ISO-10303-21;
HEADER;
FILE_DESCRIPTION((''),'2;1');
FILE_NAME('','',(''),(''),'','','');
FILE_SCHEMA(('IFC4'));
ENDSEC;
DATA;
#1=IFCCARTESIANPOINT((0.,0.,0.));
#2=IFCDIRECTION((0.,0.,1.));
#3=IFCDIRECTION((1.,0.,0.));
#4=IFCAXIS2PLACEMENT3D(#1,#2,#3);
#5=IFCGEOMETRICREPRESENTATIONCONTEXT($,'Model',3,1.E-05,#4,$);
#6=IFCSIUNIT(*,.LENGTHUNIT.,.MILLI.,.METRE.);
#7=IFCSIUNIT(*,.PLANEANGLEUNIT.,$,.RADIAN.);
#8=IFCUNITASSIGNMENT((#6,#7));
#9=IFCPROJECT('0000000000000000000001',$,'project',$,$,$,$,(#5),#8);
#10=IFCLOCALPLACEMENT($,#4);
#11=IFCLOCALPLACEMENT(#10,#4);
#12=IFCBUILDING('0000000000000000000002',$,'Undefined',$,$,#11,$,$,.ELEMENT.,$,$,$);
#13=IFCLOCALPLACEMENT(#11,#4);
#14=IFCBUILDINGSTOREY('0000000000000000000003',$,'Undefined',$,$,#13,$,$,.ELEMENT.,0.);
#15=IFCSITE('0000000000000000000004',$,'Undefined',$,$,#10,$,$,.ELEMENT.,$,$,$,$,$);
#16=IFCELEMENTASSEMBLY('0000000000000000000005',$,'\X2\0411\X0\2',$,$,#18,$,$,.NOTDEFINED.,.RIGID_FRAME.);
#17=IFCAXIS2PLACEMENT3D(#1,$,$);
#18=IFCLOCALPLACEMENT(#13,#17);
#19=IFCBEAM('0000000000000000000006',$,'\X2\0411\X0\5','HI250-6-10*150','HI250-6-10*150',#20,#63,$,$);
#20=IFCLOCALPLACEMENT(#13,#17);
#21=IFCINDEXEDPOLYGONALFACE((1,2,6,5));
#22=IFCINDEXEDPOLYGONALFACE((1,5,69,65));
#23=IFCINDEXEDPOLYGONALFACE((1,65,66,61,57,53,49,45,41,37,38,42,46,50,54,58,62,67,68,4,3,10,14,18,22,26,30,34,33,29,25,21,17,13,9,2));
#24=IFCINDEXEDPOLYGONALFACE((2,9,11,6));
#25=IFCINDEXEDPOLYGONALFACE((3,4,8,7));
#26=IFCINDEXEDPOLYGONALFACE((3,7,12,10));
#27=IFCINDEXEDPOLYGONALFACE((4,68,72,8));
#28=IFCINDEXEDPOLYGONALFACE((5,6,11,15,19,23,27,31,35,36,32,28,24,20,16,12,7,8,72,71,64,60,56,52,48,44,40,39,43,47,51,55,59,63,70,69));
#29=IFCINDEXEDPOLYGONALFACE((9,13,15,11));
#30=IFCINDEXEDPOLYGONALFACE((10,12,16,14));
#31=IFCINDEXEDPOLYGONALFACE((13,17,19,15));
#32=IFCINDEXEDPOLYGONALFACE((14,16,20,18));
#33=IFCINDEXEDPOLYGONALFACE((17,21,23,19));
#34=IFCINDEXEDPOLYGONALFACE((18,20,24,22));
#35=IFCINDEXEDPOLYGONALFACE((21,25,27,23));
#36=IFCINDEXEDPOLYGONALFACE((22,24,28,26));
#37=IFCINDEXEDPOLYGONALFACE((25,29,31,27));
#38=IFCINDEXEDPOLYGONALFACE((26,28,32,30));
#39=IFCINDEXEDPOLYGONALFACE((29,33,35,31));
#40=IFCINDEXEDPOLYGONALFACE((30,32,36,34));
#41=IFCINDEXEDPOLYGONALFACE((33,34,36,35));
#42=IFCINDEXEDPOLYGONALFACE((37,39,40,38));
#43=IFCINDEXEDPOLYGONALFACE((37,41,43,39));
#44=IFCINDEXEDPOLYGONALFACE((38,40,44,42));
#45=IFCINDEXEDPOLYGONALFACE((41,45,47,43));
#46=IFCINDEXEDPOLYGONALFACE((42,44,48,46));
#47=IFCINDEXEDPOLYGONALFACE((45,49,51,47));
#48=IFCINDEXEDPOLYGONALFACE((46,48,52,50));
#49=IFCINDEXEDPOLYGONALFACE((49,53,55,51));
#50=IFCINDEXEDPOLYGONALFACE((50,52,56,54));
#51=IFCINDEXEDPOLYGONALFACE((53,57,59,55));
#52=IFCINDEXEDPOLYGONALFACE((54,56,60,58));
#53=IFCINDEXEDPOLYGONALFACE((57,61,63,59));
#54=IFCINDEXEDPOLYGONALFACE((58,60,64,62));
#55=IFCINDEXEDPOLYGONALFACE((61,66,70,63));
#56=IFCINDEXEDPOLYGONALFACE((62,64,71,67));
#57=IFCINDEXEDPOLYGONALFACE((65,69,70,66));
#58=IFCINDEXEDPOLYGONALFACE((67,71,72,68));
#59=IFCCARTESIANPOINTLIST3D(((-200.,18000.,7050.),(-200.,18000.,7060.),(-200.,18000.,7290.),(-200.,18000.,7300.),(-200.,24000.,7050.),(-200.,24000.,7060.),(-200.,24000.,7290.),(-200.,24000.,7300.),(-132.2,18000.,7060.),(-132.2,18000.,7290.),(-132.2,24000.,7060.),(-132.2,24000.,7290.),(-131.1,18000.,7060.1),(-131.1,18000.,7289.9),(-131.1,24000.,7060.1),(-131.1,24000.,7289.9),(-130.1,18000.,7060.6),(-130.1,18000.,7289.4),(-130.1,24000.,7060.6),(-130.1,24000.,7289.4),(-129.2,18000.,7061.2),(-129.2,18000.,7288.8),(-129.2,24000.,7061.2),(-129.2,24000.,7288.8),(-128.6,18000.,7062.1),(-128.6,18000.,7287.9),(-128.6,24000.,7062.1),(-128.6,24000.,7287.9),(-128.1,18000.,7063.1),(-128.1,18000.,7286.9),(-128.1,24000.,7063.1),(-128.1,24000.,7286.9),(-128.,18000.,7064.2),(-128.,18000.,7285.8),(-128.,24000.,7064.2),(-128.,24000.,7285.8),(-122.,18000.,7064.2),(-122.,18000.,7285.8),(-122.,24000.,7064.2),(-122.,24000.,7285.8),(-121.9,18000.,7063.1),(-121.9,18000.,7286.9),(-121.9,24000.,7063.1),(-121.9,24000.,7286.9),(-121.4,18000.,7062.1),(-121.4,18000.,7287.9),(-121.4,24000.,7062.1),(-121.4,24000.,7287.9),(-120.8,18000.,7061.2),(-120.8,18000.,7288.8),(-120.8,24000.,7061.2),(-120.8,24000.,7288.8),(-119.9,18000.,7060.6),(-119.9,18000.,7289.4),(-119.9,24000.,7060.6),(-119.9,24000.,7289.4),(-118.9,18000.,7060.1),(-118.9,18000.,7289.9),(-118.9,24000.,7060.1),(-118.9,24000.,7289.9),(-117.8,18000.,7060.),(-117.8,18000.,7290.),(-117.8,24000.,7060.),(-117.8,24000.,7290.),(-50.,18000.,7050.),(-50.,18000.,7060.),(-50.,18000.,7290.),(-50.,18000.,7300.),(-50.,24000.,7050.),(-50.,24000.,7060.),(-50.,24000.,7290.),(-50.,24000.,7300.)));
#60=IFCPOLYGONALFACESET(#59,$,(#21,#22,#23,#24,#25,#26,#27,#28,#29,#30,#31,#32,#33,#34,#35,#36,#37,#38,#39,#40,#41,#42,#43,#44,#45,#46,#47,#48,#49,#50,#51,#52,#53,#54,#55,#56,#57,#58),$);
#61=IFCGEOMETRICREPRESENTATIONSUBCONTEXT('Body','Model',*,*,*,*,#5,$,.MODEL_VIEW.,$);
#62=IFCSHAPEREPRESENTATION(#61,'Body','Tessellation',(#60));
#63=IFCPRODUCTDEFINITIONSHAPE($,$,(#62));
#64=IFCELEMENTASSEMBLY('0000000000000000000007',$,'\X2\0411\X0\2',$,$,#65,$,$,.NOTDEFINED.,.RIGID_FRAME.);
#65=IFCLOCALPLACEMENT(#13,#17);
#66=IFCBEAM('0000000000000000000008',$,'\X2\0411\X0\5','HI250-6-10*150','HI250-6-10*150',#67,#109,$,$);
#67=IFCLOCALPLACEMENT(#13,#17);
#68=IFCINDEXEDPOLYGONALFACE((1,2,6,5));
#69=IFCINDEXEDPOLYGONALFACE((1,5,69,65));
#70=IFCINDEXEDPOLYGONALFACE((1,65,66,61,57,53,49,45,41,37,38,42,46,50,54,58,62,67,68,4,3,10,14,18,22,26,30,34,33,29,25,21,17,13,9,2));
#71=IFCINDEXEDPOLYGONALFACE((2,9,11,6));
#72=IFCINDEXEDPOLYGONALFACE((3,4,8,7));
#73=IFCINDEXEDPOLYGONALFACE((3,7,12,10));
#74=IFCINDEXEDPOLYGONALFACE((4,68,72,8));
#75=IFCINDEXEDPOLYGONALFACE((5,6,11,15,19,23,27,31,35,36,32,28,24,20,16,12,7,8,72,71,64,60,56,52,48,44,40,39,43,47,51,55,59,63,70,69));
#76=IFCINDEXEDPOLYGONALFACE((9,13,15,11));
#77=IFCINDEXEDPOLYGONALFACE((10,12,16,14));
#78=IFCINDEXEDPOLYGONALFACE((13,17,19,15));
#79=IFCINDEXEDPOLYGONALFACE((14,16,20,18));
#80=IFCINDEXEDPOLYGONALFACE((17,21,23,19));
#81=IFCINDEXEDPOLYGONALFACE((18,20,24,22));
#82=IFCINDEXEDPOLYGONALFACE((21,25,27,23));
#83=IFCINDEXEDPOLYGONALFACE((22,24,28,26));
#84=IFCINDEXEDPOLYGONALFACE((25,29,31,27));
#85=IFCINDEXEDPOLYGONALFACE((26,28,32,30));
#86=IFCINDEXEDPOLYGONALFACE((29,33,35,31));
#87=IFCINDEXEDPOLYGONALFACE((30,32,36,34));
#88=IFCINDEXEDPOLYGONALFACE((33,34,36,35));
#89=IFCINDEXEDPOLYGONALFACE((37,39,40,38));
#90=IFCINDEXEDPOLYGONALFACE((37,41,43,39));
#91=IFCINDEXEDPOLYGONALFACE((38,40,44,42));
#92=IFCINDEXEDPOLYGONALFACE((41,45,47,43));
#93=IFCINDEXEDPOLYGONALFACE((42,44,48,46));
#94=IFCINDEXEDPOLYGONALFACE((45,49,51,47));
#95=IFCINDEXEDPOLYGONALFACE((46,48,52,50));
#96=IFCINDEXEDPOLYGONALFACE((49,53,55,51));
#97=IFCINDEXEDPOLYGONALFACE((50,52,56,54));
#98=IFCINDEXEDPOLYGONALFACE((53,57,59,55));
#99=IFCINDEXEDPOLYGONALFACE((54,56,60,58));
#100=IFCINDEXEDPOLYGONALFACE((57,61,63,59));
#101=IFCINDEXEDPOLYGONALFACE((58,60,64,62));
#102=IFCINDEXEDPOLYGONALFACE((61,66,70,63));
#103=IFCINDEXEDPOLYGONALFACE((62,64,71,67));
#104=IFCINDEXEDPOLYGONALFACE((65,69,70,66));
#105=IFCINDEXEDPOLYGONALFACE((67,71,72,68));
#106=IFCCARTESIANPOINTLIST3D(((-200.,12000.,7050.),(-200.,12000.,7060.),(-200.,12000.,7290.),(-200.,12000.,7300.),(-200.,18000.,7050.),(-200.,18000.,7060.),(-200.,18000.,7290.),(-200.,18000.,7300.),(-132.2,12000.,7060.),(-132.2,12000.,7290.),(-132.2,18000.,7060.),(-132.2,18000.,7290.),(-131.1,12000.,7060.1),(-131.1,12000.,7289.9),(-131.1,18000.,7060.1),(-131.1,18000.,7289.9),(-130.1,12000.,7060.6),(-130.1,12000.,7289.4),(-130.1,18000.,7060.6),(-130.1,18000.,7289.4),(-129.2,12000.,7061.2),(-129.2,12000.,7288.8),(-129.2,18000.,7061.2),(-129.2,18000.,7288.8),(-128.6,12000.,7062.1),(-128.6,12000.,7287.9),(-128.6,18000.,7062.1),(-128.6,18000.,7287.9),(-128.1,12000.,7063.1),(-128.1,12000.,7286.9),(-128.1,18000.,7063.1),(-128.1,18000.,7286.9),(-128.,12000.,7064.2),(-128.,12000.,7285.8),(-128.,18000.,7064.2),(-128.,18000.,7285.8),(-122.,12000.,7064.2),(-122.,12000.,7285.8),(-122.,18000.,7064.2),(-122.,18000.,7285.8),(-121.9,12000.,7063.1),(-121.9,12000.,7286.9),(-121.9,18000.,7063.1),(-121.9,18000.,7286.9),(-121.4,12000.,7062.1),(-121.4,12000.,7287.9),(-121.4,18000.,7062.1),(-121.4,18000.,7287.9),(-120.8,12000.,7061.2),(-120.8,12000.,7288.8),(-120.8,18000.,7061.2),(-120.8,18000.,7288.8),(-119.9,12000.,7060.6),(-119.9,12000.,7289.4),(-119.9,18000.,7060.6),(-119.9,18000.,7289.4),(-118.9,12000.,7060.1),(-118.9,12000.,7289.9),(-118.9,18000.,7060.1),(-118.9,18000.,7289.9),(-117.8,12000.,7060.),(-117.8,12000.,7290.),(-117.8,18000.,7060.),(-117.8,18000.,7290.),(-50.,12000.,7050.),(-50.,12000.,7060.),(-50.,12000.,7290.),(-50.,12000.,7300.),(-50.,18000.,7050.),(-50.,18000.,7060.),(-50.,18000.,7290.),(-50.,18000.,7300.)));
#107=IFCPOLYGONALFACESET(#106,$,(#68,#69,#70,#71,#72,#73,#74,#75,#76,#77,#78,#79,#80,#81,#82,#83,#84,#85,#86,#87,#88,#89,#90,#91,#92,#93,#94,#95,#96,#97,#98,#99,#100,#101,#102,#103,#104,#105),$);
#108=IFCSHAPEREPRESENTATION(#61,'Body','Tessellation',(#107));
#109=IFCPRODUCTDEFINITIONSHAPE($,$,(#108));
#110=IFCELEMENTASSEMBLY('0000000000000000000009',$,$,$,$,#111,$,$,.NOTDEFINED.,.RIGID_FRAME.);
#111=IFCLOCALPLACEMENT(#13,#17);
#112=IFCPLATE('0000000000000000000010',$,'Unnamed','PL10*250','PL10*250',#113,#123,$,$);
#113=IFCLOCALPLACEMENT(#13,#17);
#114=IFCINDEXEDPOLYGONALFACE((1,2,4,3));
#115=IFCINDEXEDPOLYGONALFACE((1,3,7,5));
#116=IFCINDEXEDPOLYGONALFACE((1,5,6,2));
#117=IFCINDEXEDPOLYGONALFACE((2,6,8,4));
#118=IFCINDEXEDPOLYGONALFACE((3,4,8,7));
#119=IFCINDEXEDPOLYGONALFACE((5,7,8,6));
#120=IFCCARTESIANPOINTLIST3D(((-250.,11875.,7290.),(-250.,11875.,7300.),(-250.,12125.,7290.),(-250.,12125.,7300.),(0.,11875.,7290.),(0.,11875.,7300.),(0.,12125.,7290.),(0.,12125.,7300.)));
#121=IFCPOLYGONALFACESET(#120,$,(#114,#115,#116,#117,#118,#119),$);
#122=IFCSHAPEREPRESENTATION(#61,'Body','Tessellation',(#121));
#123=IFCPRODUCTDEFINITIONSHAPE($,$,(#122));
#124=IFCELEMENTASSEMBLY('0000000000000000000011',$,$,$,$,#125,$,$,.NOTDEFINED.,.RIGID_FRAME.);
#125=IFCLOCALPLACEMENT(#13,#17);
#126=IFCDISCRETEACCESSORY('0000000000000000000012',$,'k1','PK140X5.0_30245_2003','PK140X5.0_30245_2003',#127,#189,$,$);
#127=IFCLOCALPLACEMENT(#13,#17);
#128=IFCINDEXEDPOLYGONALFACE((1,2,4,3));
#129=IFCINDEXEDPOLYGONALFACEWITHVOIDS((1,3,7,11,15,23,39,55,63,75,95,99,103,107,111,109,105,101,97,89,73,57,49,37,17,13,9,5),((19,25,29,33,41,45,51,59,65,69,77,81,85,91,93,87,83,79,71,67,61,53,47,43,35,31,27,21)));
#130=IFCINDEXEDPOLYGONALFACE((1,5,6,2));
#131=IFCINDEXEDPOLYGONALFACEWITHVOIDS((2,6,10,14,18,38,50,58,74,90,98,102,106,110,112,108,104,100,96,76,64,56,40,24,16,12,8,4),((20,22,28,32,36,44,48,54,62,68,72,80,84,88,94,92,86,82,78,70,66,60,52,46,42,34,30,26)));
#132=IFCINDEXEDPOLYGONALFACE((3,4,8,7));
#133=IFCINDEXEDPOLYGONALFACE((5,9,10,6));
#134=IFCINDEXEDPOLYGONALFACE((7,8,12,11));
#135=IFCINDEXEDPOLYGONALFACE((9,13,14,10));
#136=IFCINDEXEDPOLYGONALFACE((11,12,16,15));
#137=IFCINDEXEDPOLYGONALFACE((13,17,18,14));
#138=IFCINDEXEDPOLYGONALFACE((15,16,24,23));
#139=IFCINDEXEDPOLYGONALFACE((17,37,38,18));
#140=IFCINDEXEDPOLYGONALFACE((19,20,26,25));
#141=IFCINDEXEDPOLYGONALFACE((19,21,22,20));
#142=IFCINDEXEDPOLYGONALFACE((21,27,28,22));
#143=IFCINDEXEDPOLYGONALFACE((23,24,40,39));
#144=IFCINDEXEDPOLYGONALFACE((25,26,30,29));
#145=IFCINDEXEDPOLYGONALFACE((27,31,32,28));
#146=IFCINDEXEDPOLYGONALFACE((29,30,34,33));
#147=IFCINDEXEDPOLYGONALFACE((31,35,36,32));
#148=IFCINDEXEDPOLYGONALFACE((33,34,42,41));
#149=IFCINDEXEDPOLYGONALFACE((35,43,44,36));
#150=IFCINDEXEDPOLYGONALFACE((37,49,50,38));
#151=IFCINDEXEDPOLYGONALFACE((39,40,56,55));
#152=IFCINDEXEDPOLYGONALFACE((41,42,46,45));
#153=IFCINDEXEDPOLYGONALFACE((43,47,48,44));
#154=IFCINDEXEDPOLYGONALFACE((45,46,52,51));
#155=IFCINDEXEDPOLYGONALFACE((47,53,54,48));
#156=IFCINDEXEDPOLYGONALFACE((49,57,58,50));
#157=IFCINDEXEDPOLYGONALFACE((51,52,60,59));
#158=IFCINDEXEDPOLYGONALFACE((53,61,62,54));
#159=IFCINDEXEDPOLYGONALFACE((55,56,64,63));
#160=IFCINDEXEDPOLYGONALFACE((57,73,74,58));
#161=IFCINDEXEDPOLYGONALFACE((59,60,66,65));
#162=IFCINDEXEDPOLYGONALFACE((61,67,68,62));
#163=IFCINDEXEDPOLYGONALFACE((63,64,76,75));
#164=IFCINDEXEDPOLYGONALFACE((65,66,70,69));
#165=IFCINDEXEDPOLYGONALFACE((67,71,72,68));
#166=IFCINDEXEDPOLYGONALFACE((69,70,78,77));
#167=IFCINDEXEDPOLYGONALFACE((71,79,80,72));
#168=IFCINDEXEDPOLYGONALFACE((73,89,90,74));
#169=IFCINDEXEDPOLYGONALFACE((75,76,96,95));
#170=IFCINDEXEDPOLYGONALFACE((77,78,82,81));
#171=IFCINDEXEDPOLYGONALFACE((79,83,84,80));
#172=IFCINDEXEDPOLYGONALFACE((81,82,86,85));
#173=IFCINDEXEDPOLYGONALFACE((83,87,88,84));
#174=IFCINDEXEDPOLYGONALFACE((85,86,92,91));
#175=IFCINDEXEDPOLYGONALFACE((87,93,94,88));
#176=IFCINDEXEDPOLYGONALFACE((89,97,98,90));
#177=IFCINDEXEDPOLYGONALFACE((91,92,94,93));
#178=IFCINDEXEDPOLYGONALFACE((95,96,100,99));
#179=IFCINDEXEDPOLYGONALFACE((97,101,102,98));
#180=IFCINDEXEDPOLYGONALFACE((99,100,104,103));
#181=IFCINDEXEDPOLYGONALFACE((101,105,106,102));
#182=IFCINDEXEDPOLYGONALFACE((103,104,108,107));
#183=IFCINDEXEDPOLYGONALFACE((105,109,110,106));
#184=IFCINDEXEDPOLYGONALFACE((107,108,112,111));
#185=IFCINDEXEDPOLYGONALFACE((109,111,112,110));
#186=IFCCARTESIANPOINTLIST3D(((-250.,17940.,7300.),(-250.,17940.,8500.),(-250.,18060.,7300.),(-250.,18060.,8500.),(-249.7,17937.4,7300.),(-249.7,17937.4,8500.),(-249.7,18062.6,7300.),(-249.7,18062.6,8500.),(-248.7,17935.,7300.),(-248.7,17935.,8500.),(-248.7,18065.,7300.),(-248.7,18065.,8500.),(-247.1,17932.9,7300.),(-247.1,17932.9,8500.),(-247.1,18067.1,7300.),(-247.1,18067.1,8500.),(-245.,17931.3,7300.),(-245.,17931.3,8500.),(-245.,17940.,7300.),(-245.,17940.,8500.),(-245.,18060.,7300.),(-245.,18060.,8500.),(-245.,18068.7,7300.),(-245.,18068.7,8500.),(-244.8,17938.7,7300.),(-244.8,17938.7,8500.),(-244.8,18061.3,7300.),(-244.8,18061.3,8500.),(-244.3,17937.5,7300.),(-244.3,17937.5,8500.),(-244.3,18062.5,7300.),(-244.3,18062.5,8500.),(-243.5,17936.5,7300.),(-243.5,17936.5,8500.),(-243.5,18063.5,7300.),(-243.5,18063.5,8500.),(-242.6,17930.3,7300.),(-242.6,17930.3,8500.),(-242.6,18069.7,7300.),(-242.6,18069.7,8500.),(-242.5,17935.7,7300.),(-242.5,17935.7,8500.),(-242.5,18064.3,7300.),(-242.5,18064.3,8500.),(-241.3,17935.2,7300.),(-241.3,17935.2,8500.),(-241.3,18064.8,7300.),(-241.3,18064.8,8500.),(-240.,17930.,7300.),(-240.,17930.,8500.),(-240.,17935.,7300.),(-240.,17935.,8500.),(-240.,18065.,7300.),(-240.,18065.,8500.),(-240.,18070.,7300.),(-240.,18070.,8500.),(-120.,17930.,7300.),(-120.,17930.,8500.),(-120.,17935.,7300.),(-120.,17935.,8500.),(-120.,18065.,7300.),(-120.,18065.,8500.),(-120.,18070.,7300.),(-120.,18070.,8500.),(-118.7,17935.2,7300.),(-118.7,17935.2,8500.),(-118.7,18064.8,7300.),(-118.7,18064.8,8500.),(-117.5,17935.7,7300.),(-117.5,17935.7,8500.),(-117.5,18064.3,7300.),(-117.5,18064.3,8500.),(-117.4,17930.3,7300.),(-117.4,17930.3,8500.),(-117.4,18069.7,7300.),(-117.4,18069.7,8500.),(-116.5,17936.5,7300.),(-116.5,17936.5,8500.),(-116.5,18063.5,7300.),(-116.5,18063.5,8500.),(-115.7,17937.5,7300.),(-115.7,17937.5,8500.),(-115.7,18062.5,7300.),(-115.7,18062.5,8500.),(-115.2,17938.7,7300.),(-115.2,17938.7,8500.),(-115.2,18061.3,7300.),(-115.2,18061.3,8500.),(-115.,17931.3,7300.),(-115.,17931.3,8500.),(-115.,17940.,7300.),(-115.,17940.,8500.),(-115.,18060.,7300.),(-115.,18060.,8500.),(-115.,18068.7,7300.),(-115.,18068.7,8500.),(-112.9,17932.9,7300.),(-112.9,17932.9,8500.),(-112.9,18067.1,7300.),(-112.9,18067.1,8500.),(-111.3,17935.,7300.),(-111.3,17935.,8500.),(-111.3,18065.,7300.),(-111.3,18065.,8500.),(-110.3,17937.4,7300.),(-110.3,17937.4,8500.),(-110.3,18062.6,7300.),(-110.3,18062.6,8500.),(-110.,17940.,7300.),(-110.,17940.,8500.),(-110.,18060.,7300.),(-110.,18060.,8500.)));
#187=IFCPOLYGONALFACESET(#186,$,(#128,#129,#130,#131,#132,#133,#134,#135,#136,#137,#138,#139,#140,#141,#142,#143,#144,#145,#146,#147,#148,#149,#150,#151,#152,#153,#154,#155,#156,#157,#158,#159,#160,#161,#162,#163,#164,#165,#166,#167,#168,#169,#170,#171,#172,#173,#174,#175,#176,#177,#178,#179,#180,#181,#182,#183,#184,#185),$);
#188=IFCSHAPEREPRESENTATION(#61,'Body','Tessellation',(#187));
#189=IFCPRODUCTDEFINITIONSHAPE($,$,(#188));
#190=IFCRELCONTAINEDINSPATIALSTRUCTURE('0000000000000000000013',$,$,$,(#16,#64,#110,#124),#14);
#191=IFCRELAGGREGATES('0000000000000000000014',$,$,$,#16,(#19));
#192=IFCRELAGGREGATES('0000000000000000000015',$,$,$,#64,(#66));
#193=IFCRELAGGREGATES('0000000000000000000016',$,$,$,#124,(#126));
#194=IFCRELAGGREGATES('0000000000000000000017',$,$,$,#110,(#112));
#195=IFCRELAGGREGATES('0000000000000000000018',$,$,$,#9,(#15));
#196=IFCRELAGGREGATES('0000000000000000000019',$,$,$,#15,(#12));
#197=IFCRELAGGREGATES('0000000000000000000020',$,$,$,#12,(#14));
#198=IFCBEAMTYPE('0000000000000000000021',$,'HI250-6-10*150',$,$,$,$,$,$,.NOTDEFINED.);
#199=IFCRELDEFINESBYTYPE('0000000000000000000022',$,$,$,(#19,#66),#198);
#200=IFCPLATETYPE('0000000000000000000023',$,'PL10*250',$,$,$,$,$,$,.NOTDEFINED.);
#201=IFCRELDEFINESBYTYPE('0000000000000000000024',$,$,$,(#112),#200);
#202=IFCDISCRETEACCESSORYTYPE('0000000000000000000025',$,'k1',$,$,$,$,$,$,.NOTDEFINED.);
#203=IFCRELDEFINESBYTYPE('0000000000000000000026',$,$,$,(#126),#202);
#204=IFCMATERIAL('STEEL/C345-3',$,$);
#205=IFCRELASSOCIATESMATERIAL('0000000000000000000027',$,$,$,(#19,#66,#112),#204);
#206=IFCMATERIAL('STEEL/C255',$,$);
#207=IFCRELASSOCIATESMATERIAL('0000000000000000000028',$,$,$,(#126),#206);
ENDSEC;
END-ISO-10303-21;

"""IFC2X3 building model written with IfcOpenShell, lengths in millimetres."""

from ifc_helpers import new_model, si_unit, frame, origin_with_axes, origin_2d_with_axis, place, context, subcontext, project, spatial, polyline, hollow_rectangle, i_section, outline, extrude, material, type_object, element, aggregate, save


model = new_model("IFC2X3")

# Units and contexts
model_context = context("Model", 3, precision=1e-05, world=origin_with_axes())
body_context = subcontext(model_context, "Body", "Model", "MODEL_VIEW")
ifc_project = project(units=[si_unit("LENGTHUNIT", "METRE", prefix="MILLI"), si_unit("PLANEANGLEUNIT", "RADIAN")], contexts=[model_context])

# Site, building, storey
site_placement = place(None, origin_with_axes())
site = spatial("IfcSite", under=ifc_project, at=site_placement, Name="Undefined", CompositionType="ELEMENT")
building_placement = place(site_placement, origin_with_axes())
building = spatial("IfcBuilding", under=site, at=building_placement, Name="Undefined", CompositionType="ELEMENT")
storey_placement = place(building_placement, origin_with_axes())
storey = spatial("IfcBuildingStorey", under=building, at=storey_placement, Name="Undefined", CompositionType="ELEMENT", Elevation=0.0)

# Element assemblies, beams
ifc_material_1 = material(Name="STEEL/C345-3")
assembly_1_placement = place(storey_placement, origin_with_axes())
assembly_1 = element("IfcElementAssembly", 1, at=assembly_1_placement, inside=storey, Name="Б2", AssemblyPlace="NOTDEFINED", PredefinedType="RIGID_FRAME")
beam_type_1 = type_object("IfcBeamType", Name="HI250-6-10*150", PredefinedType="NOTDEFINED")
beam_1_placement = place(assembly_1_placement, frame((-125.0, 18000.0, 7175.0), z_axis=(0.0, 0.0, -1.0), x_axis=(0.0, 1.0, 0.0)))
beam_1 = element("IfcBeam", 2, at=beam_1_placement, type_object=beam_type_1, material=ifc_material_1, Name="Б5", Description="HI250-6-10*150", ObjectType="HI250-6-10*150", context=body_context, shape_type="SweptSolid", body=[
    extrude(i_section(OverallWidth=150.0, OverallDepth=250.0, WebThickness=6.0, FlangeThickness=10.0, FilletRadius=4.2, at=origin_2d_with_axis()), frame((6000.0, 0.0, 0.0), z_axis=(-1.0, 0.0, 0.0), x_axis=(0.0, -1.0, 0.0)), (0.0, 0.0, 1.0), 6000.0),
])
aggregate(assembly_1, [beam_1])
assembly_2_placement = place(storey_placement, origin_with_axes())
assembly_2 = element("IfcElementAssembly", 3, at=assembly_2_placement, inside=storey, Name="Б2", AssemblyPlace="NOTDEFINED", PredefinedType="RIGID_FRAME")
beam_2_placement = place(assembly_2_placement, frame((-125.0, 12000.0, 7175.0), z_axis=(0.0, 0.0, -1.0), x_axis=(0.0, 1.0, 0.0)))
beam_2 = element("IfcBeam", 4, at=beam_2_placement, type_object=beam_type_1, material=ifc_material_1, Name="Б5", Description="HI250-6-10*150", ObjectType="HI250-6-10*150", context=body_context, shape_type="SweptSolid", body=[
    extrude(i_section(OverallWidth=150.0, OverallDepth=250.0, WebThickness=6.0, FlangeThickness=10.0, FilletRadius=4.2, at=origin_2d_with_axis()), frame((6000.0, 0.0, 0.0), z_axis=(-1.0, 0.0, 0.0), x_axis=(0.0, -1.0, 0.0)), (0.0, 0.0, 1.0), 6000.0),
])
aggregate(assembly_2, [beam_2])

# Element assembly, plate
assembly_3_placement = place(storey_placement, origin_with_axes())
assembly_3 = element("IfcElementAssembly", 5, at=assembly_3_placement, inside=storey, AssemblyPlace="NOTDEFINED", PredefinedType="RIGID_FRAME")
plate_type = type_object("IfcPlateType", Name="PL10*250", PredefinedType="NOTDEFINED")
plate_placement = place(assembly_3_placement, frame((-250.0, 12125.0, 7295.0), z_axis=(0.0, 0.0, 1.0), x_axis=(0.0, -1.0, 0.0)))
plate = element("IfcPlate", 6, at=plate_placement, type_object=plate_type, material=ifc_material_1, Name="Unnamed", Description="PL10*250", ObjectType="PL10*250", context=body_context, shape_type="SweptSolid", body=[
    extrude(outline(polyline([(0.0, 0.0), (250.0, 0.0), (250.0, 250.0), (0.0, 250.0), (0.0, 0.0)])), frame((0.0, 0.0, -5.0), z_axis=(0.0, 0.0, 1.0), x_axis=(1.0, 0.0, 0.0)), (0.0, 0.0, 1.0), 10.0),
])

# Element assembly, discrete accessory
assembly_4_placement = place(storey_placement, origin_with_axes())
assembly_4 = element("IfcElementAssembly", 7, at=assembly_4_placement, inside=storey, AssemblyPlace="NOTDEFINED", PredefinedType="RIGID_FRAME")
ifc_material_2 = material(Name="STEEL/C255")
discrete_accessory_type = type_object("IfcDiscreteAccessoryType", Name="k1")
discrete_accessory_1_placement = place(assembly_4_placement, frame((-180.0, 18000.0, 7300.0), z_axis=(0.0, 0.0, 1.0), x_axis=(1.0, 0.0, 0.0)))
discrete_accessory_1 = element("IfcDiscreteAccessory", 8, at=discrete_accessory_1_placement, type_object=discrete_accessory_type, material=ifc_material_2, Name="k1", Description="PK140X5.0_30245_2003", ObjectType="PK140X5.0_30245_2003", context=body_context, shape_type="SweptSolid", body=[
    extrude(hollow_rectangle(XDim=140.0, YDim=140.0, WallThickness=5.0, InnerFilletRadius=5.0, OuterFilletRadius=10.0, at=origin_2d_with_axis()), frame((0.0, 0.0, 1200.0), z_axis=(0.0, 0.0, -1.0), x_axis=(0.0, 1.0, 0.0)), (0.0, 0.0, 1.0), 1200.0),
])
aggregate(assembly_4, [discrete_accessory_1])

aggregate(assembly_3, [plate])

save(model, "model.ifc")
